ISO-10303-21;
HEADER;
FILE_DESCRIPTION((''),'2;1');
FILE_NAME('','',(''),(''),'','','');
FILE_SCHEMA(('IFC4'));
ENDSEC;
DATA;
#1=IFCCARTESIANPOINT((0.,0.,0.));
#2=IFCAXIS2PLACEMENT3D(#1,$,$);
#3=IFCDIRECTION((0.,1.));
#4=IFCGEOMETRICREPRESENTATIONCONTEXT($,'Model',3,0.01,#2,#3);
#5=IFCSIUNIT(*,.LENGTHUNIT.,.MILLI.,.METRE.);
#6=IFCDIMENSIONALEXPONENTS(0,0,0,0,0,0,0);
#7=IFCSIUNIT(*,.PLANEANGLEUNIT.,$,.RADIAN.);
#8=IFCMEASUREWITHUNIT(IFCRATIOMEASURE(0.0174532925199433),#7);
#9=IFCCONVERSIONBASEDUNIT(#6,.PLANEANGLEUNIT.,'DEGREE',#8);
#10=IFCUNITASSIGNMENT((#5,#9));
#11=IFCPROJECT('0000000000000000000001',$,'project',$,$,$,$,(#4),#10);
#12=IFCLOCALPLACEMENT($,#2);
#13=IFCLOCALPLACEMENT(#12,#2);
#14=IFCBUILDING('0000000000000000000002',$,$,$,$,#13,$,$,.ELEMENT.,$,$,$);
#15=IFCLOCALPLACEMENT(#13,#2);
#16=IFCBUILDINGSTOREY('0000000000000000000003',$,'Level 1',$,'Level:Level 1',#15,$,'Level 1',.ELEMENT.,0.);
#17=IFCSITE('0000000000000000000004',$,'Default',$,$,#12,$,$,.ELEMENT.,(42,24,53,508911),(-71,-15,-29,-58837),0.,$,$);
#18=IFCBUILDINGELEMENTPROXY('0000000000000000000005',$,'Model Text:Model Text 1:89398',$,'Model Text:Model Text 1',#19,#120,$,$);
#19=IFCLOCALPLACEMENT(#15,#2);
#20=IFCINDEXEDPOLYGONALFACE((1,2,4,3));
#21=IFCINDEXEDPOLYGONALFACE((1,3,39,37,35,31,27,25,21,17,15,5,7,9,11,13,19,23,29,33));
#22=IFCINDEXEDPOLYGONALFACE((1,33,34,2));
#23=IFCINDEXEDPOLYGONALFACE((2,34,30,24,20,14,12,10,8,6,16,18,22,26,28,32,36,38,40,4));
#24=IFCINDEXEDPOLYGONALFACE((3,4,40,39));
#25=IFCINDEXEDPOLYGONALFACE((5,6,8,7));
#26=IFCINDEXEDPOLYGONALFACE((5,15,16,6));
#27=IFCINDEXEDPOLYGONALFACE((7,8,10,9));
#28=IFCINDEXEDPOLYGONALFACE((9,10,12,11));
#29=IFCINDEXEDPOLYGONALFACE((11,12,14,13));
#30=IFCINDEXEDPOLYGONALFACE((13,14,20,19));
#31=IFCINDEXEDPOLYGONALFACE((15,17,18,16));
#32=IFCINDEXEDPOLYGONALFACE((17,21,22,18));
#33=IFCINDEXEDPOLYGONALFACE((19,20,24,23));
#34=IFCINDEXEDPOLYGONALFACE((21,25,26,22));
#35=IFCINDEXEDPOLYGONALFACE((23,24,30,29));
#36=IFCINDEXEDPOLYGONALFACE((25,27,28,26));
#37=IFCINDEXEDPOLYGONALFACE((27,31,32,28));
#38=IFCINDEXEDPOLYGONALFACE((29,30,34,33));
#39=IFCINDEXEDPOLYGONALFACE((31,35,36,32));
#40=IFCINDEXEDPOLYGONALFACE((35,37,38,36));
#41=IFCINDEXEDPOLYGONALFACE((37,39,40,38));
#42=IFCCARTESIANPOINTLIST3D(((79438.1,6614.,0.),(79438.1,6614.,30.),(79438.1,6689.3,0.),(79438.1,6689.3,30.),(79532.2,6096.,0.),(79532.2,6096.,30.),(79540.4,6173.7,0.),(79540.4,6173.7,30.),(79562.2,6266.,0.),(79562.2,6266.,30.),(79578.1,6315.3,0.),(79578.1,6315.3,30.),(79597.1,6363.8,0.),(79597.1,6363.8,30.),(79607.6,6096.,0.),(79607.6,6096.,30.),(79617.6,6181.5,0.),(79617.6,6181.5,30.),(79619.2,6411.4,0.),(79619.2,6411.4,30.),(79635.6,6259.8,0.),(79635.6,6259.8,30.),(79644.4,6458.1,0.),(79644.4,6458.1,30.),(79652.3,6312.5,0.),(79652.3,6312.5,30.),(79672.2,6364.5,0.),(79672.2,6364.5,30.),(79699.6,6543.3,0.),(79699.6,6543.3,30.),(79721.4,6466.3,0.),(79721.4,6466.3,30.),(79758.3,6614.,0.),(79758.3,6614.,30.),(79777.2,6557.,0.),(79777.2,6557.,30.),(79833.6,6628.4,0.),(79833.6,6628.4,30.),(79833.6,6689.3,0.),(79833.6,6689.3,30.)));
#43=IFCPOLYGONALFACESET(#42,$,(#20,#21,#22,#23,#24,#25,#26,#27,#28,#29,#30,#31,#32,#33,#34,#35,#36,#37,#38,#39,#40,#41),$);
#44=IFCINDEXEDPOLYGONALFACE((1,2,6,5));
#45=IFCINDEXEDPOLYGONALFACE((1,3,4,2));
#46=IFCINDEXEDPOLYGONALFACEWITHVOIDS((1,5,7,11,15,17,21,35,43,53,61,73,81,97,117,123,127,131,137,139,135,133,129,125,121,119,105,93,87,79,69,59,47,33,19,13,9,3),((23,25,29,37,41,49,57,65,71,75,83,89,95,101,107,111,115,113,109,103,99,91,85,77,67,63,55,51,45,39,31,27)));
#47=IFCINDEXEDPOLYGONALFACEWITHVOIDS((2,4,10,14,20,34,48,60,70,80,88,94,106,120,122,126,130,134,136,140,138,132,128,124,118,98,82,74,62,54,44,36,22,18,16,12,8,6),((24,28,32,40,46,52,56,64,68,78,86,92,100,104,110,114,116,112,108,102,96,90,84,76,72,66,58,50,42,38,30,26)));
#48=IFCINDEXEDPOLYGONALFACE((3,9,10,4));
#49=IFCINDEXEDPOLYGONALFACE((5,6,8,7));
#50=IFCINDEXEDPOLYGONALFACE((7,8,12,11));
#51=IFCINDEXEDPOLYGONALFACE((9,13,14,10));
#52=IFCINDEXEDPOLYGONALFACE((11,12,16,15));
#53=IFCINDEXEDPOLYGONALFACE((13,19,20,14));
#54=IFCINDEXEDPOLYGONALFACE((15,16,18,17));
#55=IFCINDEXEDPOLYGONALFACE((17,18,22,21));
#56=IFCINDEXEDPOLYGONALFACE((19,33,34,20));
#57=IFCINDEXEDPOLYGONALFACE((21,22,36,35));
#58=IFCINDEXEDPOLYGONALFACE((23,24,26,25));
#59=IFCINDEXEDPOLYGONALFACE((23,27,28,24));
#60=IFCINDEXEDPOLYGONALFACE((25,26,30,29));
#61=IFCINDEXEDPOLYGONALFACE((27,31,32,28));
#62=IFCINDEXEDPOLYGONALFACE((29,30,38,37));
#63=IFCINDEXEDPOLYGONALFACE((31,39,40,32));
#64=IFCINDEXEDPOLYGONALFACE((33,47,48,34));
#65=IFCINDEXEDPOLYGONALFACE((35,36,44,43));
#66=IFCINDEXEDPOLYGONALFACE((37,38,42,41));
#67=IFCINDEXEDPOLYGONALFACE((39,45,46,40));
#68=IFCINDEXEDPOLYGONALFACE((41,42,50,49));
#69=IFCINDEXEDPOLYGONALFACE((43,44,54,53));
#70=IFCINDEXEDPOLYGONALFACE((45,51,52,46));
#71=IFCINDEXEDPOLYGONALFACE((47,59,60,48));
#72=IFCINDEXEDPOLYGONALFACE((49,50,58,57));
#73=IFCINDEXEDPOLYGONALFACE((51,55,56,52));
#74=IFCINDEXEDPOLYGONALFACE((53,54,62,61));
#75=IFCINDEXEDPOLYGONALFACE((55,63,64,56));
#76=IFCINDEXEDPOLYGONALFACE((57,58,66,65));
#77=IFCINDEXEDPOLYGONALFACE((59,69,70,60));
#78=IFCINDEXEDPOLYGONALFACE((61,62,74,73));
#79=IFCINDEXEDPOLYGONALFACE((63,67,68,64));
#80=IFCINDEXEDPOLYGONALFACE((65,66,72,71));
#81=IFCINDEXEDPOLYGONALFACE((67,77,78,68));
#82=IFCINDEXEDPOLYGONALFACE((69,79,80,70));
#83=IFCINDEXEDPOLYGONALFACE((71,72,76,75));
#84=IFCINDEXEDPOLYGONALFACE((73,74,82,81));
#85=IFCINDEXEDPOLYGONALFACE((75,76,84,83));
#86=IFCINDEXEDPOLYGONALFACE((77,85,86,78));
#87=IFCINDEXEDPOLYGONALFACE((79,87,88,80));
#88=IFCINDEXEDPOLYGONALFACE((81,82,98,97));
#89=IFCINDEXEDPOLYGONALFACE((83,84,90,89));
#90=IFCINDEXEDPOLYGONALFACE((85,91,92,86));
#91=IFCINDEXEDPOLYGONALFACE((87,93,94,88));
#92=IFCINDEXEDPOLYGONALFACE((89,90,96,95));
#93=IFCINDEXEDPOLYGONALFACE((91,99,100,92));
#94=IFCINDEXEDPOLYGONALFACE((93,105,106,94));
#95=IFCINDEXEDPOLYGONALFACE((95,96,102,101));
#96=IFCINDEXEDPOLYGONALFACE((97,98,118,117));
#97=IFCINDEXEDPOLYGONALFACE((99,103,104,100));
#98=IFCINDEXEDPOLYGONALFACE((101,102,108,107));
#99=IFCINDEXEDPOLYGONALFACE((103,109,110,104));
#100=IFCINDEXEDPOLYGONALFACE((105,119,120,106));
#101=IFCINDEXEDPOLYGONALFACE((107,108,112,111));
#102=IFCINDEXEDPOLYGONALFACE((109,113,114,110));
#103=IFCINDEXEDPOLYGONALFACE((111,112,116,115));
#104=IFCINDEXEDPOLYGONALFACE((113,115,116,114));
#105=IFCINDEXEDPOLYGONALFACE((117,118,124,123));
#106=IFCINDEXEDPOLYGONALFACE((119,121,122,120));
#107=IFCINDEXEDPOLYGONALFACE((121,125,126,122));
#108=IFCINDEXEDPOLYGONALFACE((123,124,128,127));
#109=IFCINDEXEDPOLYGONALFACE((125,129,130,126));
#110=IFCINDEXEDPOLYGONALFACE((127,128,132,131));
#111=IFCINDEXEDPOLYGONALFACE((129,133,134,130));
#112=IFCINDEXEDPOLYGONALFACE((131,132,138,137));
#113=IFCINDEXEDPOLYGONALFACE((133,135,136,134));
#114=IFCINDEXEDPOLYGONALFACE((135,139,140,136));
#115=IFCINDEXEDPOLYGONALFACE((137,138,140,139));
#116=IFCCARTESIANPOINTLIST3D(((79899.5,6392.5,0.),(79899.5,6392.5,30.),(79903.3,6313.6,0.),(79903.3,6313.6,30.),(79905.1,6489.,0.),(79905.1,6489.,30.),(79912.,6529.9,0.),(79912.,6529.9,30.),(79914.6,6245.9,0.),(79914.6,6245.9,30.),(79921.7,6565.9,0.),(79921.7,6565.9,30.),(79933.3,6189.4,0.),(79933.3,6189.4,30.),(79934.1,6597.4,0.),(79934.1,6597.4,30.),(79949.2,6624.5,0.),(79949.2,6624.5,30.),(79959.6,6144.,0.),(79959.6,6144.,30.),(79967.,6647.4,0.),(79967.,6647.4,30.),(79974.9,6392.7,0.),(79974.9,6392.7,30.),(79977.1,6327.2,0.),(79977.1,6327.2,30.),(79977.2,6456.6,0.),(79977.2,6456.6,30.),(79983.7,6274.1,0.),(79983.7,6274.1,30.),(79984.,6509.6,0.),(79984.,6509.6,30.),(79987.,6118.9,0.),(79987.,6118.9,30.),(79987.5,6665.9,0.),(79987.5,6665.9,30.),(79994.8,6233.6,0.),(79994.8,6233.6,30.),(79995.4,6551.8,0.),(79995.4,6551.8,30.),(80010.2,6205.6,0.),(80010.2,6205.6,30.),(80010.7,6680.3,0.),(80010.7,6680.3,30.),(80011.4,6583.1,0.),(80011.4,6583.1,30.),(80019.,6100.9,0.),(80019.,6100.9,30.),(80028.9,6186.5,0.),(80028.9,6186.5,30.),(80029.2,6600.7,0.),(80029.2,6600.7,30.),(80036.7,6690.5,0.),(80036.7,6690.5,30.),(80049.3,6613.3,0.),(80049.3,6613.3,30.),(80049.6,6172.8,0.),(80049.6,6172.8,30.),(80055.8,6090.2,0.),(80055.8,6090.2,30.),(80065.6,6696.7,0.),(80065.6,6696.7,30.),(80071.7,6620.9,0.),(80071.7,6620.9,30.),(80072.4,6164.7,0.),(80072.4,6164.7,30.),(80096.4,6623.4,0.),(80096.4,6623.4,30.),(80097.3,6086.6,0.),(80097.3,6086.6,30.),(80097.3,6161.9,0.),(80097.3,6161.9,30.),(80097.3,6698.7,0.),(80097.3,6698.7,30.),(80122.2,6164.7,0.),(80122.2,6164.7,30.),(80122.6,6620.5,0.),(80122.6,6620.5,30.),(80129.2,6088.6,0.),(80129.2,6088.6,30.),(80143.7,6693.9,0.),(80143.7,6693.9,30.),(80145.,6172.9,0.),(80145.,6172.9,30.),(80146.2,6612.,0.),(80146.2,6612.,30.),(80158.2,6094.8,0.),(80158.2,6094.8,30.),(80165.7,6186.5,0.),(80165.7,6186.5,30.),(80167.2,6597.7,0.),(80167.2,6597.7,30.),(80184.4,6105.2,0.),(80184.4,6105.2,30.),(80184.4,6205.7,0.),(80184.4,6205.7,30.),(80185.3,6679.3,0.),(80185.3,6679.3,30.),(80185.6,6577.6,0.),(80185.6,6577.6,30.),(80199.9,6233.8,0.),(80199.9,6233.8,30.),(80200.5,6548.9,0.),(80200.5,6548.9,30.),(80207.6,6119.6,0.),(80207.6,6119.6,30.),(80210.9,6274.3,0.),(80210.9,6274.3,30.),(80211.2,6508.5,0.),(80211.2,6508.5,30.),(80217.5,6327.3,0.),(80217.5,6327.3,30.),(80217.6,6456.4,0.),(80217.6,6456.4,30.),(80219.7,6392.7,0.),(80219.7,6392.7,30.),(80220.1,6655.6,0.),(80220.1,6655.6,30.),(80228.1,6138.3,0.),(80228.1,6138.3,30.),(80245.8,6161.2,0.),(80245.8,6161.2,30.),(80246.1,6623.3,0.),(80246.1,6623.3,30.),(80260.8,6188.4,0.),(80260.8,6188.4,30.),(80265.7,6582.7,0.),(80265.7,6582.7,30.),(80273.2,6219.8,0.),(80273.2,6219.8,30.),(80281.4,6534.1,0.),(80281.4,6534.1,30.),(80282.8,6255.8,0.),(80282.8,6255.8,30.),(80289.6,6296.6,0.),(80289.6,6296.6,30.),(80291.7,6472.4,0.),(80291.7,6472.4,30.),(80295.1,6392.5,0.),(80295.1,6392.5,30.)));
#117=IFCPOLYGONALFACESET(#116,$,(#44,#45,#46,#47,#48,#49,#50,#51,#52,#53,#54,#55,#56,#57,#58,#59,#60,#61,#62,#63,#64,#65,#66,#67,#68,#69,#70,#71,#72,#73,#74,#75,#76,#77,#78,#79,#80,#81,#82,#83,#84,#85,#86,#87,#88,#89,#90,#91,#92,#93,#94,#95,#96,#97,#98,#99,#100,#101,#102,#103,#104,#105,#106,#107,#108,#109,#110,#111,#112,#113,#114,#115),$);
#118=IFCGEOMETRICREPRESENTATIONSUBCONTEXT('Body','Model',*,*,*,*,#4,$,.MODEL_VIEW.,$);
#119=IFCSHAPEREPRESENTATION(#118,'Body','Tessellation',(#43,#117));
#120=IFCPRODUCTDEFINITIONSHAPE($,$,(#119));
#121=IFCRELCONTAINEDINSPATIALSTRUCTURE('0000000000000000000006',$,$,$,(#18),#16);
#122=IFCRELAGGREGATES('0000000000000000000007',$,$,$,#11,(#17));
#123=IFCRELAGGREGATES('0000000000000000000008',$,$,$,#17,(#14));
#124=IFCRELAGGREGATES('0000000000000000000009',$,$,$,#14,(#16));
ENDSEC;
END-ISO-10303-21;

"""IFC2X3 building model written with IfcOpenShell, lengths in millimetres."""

from ifc_helpers import new_model, entity, si_unit, converted_unit, direction, frame, origin, place, context, subcontext, project, spatial, polyline, outline, extrude, element, save


model = new_model("IFC2X3")

# Units and contexts
model_context = context("Model", 3, precision=0.01, world=origin(), true_north=direction((0.0, 1.0)))
body_context = subcontext(model_context, "Body", "Model", "MODEL_VIEW")
ifc_project = project(units=[si_unit("LENGTHUNIT", "METRE", prefix="MILLI"), converted_unit("PLANEANGLEUNIT", "DEGREE", entity("IfcRatioMeasure", 0.0174532925199433), si_unit("PLANEANGLEUNIT", "RADIAN"), dimensions=[0, 0, 0, 0, 0, 0, 0])], contexts=[model_context])

# Site, building, storey
site_placement = place(None, origin())
site = spatial("IfcSite", under=ifc_project, at=site_placement, Name="Default", CompositionType="ELEMENT", RefLatitude=(42, 24, 53, 508911), RefLongitude=(-71, -15, -29, -58837), RefElevation=0.0)
building_placement = place(site_placement, origin())
building = spatial("IfcBuilding", under=site, at=building_placement, CompositionType="ELEMENT")
storey_placement = place(building_placement, origin())
storey = spatial("IfcBuildingStorey", under=building, at=storey_placement, Name="Level 1", ObjectType="Level:Level 1", LongName="Level 1", CompositionType="ELEMENT", Elevation=0.0)

# Building element proxy
proxy_1_placement = place(storey_placement, origin())
element("IfcBuildingElementProxy", 1, at=proxy_1_placement, inside=storey, Name="Model Text:Model Text 1:89398", ObjectType="Model Text:Model Text 1", context=body_context, shape_type="SweptSolid", body=[
    extrude(outline(polyline([(-199.9, -209.0), (-199.9, -284.3), (195.7, -284.3), (195.7, -223.4), (139.3, -152.0), (83.5, -61.3), (34.2, 40.5), (14.4, 92.5), (-2.4, 145.2), (-20.3, 223.5), (-30.3, 309.0), (-105.7, 309.0), (-97.5, 231.3), (-75.7, 139.0), (-59.9, 89.7), (-40.9, 41.2), (-18.8, -6.4), (6.4, -53.1), (61.7, -138.3), (120.3, -209.0), (-199.9, -209.0)])), frame((79637.9, 6405.0, 0.0), z_axis=(0.0, 0.0, -1.0), x_axis=(1.0, 0.0, 0.0)), (0.0, 0.0, -1.0), 30.0),
    extrude(outline(polyline([(-10.6, -198.7), (68.3, -198.7), (136.5, -190.7), (193.9, -174.7), (240.5, -150.6), (266.9, -124.4), (286.3, -93.2), (298.8, -57.0), (304.3, -15.7), (303.8, 16.2), (299.0, 45.5), (289.9, 72.1), (276.6, 96.0), (258.9, 117.3), (236.9, 136.2), (210.4, 152.5), (179.6, 166.3), (144.1, 177.6), (103.7, 186.3), (8.2, 196.4), (-71.8, 196.7), (-134.0, 189.4), (-183.3, 176.1), (-224.7, 158.4), (-258.2, 133.9), (-283.5, 100.3), (-300.1, 59.5), (-307.1, 13.4), (-306.6, -18.4), (-301.8, -47.5), (-292.8, -74.0), (-279.6, -97.9), (-262.0, -119.2), (-240.0, -138.1), (-213.6, -154.5), (-182.8, -168.4), (-147.3, -179.8), (-106.7, -188.6), (-10.6, -198.7)]), holes=[polyline([(-7.2, -123.5), (-71.0, -118.2), (-123.6, -108.8), (-165.2, -95.4), (-195.7, -78.0), (-212.4, -59.4), (-224.1, -38.7), (-230.6, -15.9), (-231.9, 8.9), (-227.8, 35.0), (-218.1, 58.1), (-202.8, 78.4), (-182.0, 95.8), (-152.6, 109.4), (-111.7, 118.1), (-59.4, 122.0), (4.4, 121.1), (69.6, 115.8), (122.2, 106.7), (162.2, 93.7), (189.5, 77.0), (207.7, 57.4), (220.4, 36.0), (227.5, 12.8), (229.1, -12.1), (225.2, -36.8), (215.9, -59.2), (201.3, -79.3), (181.4, -97.1), (152.6, -111.2), (111.6, -120.3), (58.3, -124.4), (-7.2, -123.5)])]), frame((80098.6, 6391.3, 0.0), z_axis=(0.0, 0.0, 1.0), x_axis=(0.047515, -0.998871, 0.0)), (0.0, 0.0, 1.0), 30.0),
])

save(model, "model.ifc")
